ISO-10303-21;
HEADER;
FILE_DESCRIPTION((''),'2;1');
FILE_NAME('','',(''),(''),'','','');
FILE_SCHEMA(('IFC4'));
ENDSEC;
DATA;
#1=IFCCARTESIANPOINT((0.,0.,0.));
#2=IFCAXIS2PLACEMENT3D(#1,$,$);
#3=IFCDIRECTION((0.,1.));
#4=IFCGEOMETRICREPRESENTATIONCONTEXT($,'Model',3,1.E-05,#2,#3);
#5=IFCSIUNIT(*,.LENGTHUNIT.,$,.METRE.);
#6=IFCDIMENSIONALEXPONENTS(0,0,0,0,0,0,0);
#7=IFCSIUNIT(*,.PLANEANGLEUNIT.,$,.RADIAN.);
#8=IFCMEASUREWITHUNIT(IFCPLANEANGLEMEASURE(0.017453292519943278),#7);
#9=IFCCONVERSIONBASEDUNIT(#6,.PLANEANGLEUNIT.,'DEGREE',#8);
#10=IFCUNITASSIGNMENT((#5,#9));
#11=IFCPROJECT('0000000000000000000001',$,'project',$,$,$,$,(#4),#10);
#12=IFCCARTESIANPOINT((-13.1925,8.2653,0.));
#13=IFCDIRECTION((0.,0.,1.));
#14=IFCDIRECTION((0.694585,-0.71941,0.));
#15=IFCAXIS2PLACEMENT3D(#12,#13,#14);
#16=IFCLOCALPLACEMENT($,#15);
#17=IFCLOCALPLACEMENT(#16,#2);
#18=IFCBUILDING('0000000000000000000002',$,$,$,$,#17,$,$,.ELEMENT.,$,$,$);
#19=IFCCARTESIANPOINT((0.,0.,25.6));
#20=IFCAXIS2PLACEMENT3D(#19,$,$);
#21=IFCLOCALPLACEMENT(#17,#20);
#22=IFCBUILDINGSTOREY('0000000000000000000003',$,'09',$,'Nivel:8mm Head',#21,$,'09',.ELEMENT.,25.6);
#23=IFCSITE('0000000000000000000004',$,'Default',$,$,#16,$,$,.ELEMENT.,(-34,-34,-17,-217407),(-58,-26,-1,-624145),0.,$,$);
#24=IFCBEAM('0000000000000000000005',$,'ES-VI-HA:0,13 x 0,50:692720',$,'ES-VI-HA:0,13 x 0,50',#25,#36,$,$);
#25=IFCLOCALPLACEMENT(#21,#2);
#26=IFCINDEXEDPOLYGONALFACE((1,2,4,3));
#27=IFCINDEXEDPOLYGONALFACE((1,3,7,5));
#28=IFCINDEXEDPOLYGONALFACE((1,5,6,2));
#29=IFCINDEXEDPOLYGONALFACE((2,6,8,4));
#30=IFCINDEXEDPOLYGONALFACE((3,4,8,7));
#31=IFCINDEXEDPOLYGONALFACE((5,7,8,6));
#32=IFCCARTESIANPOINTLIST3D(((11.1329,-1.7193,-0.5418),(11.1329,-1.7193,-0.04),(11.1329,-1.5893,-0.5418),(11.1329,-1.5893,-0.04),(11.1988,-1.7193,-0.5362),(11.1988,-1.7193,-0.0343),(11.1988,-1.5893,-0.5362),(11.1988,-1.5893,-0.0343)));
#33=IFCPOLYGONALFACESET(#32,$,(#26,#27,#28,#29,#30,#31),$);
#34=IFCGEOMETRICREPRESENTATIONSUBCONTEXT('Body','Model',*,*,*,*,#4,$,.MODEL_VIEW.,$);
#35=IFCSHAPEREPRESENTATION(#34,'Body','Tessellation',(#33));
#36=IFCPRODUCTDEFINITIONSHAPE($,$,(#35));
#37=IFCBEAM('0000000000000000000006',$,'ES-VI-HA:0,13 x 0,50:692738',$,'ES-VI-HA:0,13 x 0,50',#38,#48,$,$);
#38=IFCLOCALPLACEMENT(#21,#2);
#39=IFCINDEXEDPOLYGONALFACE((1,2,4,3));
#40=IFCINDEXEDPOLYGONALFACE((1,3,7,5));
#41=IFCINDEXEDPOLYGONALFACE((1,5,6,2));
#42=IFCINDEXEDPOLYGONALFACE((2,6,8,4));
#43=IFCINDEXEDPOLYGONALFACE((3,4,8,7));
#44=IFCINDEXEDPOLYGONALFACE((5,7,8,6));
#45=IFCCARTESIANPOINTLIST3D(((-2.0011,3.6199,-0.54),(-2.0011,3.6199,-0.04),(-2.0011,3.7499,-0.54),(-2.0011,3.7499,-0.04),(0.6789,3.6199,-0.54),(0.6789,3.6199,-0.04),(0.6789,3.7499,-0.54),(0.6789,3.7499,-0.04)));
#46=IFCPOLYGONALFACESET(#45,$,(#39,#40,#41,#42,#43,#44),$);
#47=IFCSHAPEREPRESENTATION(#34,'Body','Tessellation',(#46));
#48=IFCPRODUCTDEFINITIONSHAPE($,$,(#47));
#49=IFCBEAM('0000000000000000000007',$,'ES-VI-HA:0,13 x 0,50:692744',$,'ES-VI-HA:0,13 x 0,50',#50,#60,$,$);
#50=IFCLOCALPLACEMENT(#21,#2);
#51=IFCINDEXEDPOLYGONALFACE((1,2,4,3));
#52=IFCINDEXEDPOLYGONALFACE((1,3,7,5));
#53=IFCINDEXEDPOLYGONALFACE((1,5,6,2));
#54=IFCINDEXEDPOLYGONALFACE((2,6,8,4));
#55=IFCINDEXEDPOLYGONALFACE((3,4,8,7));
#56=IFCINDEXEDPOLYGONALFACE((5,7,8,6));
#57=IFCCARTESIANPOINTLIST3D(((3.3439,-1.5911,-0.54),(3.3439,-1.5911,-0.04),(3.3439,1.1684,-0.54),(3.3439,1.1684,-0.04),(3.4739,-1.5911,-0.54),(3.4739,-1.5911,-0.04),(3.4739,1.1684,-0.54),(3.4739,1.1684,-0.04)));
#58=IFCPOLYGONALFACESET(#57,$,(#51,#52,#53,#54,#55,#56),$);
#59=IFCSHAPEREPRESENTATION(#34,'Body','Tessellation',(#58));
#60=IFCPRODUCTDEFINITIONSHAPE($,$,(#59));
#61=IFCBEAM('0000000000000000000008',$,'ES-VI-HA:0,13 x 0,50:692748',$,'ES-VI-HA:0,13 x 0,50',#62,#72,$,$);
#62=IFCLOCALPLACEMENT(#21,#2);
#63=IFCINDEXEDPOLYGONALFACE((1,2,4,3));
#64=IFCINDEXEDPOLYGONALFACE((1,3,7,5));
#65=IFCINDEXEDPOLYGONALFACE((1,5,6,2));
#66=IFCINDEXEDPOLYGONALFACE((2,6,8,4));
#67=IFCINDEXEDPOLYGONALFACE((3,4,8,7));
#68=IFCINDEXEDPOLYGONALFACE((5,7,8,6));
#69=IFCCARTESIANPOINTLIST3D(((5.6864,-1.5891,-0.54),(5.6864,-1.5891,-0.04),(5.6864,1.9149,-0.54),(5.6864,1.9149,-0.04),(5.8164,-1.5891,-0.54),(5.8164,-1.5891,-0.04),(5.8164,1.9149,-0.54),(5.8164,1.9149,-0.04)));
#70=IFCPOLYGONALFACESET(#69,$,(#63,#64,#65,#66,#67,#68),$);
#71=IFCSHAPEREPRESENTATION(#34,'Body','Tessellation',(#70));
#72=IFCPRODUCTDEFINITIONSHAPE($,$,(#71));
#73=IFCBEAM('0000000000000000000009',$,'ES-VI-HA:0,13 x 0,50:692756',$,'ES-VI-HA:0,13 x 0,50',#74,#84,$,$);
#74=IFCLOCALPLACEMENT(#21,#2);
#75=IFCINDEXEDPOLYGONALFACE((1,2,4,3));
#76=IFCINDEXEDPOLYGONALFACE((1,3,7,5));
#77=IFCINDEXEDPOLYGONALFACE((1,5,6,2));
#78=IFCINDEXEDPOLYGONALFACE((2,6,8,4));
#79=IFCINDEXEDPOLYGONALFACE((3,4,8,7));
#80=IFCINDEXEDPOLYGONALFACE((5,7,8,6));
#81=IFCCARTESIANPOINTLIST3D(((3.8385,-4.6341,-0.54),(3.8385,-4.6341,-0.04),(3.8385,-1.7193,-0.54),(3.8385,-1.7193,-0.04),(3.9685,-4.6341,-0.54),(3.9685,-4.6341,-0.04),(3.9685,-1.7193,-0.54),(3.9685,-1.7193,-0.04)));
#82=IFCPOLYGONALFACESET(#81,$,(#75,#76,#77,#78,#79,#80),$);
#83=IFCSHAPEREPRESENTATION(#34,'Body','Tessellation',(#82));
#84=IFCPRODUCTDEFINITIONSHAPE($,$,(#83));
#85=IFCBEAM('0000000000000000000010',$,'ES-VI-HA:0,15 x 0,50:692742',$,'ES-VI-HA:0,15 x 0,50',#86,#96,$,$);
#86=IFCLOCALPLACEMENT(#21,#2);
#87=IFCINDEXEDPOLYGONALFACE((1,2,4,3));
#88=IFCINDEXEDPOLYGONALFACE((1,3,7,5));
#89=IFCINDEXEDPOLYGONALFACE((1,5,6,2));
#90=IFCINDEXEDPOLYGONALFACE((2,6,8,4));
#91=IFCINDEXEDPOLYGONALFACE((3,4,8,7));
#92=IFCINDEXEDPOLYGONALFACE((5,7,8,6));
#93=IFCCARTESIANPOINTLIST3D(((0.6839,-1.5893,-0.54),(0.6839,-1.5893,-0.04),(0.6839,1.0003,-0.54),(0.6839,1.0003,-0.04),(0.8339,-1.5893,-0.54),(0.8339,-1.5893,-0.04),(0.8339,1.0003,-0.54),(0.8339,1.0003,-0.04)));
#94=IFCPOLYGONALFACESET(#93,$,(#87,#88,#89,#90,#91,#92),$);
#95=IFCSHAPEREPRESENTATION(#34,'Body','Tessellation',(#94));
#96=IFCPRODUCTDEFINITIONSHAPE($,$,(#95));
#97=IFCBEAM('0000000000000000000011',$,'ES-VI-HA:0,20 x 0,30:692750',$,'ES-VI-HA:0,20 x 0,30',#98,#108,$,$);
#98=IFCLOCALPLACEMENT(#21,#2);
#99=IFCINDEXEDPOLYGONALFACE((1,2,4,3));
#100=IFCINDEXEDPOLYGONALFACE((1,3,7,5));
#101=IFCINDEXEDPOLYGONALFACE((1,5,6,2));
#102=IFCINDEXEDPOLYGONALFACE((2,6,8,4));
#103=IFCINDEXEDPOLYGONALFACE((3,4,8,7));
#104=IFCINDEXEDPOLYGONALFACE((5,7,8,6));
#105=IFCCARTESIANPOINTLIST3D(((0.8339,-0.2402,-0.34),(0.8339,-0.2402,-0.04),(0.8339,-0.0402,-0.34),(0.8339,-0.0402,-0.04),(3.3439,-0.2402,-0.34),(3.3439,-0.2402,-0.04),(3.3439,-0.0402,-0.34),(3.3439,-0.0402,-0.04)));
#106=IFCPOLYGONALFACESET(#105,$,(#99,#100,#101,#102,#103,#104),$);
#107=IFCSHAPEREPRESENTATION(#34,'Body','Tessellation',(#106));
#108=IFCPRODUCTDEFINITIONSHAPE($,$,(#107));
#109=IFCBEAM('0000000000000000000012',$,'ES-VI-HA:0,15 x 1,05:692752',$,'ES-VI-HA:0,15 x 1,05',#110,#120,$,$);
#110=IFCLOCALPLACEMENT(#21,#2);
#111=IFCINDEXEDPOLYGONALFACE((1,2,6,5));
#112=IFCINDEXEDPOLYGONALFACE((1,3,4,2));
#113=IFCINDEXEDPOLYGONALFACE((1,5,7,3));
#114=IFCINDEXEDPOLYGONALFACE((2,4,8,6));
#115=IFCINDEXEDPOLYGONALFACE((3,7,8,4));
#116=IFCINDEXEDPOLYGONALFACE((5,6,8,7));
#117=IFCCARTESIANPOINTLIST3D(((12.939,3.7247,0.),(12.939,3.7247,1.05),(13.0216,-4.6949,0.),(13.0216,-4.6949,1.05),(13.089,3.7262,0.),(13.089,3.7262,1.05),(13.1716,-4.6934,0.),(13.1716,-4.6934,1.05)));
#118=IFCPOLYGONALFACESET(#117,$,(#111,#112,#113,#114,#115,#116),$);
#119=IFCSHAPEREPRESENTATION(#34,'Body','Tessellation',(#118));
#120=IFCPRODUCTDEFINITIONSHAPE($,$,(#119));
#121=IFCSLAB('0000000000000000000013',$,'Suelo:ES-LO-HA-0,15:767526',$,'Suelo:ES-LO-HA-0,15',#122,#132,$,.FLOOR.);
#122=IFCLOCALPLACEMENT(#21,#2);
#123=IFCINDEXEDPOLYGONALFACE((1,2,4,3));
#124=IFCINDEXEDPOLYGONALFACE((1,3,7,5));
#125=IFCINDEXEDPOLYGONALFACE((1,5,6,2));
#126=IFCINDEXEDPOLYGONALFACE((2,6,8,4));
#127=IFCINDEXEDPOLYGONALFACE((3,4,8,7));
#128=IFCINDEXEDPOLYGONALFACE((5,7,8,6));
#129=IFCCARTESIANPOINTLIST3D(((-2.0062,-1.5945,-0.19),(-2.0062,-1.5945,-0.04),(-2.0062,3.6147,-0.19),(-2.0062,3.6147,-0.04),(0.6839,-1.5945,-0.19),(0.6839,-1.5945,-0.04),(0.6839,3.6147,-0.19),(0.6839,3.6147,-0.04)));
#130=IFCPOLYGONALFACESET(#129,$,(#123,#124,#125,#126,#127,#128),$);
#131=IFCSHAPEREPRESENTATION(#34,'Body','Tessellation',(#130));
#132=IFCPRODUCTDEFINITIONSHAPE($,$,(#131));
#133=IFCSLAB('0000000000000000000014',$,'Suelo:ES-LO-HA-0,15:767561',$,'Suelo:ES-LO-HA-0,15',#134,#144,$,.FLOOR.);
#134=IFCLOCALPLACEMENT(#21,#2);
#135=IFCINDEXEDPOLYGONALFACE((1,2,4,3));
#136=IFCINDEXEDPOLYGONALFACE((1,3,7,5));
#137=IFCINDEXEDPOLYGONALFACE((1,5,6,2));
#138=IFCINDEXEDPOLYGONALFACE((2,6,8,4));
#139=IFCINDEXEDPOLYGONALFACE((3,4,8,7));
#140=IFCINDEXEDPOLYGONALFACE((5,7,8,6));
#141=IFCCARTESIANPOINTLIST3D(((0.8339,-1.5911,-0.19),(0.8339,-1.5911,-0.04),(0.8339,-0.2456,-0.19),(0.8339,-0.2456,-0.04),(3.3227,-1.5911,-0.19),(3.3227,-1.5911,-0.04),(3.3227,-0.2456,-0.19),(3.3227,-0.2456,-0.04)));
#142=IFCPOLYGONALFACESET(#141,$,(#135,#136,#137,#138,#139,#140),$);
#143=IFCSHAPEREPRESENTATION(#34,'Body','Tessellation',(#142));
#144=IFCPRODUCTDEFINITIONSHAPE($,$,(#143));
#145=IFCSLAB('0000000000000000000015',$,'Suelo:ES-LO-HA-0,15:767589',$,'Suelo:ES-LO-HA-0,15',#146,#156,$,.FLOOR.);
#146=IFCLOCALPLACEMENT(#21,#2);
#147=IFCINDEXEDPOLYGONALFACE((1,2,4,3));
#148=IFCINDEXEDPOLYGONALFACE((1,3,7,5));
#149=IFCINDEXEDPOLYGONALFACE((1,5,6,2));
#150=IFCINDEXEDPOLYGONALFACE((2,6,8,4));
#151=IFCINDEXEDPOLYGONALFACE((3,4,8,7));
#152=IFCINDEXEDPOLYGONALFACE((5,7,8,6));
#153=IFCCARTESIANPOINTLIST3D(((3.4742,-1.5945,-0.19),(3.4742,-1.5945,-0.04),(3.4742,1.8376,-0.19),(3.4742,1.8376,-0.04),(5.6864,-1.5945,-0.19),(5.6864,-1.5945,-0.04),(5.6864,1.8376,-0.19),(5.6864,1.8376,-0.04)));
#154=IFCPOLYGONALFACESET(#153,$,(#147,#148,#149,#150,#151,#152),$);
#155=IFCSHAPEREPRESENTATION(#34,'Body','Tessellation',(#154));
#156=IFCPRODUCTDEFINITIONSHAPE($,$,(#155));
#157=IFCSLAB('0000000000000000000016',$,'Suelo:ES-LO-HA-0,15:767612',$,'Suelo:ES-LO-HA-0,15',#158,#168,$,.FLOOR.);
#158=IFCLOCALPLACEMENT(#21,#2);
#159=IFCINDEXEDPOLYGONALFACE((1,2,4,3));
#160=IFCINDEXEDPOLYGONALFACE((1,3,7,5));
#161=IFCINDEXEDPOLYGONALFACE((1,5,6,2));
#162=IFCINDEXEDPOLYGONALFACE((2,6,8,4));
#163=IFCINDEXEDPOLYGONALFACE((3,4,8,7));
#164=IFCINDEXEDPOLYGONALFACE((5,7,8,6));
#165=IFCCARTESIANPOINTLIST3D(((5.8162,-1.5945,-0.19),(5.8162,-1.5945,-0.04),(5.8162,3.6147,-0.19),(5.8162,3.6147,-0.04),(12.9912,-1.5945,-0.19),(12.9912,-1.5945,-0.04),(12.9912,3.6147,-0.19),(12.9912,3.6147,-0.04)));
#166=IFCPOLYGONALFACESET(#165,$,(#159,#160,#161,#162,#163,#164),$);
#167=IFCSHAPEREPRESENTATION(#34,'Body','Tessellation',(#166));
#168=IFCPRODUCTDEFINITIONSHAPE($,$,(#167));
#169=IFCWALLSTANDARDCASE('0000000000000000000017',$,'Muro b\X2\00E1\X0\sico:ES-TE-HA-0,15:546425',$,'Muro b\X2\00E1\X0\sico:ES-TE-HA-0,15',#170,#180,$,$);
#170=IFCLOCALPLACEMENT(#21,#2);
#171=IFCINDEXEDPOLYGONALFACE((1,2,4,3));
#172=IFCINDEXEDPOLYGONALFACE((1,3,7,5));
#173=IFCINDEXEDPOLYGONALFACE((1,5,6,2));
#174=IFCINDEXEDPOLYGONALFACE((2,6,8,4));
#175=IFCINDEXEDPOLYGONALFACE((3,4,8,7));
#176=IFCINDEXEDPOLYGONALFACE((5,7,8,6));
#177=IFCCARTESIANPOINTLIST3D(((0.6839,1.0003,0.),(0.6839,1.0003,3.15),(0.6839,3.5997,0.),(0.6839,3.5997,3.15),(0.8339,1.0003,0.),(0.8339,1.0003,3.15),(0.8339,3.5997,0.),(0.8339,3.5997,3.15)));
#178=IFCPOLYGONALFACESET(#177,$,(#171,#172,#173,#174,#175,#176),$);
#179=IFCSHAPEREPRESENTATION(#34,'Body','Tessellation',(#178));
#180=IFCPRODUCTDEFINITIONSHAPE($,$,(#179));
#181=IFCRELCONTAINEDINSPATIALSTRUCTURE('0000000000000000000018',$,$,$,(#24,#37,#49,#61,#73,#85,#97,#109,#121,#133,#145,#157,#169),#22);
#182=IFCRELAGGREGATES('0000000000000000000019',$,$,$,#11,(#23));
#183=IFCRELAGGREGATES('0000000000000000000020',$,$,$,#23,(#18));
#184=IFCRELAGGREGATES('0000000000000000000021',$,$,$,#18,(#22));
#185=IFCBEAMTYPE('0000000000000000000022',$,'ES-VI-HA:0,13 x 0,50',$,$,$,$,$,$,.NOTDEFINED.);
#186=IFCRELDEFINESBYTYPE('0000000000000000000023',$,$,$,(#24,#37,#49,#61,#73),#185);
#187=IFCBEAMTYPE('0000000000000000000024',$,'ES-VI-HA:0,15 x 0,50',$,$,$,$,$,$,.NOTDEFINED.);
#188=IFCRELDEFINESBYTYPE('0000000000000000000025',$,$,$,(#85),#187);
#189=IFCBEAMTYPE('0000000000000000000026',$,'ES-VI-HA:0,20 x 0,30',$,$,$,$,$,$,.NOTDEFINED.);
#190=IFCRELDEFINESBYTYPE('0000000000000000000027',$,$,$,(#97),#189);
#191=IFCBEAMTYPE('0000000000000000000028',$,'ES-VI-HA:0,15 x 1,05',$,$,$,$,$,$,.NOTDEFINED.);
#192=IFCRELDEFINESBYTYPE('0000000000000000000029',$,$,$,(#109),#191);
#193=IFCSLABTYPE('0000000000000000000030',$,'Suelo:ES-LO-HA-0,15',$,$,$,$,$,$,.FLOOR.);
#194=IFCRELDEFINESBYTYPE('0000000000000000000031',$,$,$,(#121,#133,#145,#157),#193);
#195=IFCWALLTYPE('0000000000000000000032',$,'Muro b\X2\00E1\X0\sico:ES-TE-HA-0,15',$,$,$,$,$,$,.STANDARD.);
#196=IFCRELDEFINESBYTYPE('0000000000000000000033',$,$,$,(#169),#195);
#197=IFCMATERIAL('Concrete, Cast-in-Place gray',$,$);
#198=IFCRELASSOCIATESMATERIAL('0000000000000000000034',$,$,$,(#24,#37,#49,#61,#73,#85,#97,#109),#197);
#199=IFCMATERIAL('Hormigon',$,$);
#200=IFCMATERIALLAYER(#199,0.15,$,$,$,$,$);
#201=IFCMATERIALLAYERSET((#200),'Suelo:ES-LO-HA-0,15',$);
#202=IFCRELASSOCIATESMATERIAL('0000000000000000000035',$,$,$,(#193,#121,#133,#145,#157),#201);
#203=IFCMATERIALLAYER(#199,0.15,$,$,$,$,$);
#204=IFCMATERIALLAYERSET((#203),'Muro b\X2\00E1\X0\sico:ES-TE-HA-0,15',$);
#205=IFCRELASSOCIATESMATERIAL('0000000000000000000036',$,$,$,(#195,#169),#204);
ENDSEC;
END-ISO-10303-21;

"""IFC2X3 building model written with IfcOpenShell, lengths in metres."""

from ifc_helpers import new_model, entity, si_unit, converted_unit, direction, frame, frame_2d, origin, origin_2d_with_axis, place, context, subcontext, project, spatial, rectangle, extrude, clip, halfspace, material, layer, layer_set, layer_usage, type_object, element, save


model = new_model("IFC2X3")

# Units and contexts
model_context = context("Model", 3, precision=1e-05, world=origin(), true_north=direction((0.0, 1.0)))
body_context = subcontext(model_context, "Body", "Model", "MODEL_VIEW")
ifc_project = project(units=[si_unit("LENGTHUNIT", "METRE"), converted_unit("PLANEANGLEUNIT", "DEGREE", entity("IfcPlaneAngleMeasure", 0.017453292519943278), si_unit("PLANEANGLEUNIT", "RADIAN"), dimensions=[0, 0, 0, 0, 0, 0, 0])], contexts=[model_context])

# Site, building, storey
site_placement = place(None, frame((-13.1925, 8.2653, 0.0), z_axis=(0.0, 0.0, 1.0), x_axis=(0.694585, -0.71941, 0.0)))
site = spatial("IfcSite", under=ifc_project, at=site_placement, Name="Default", CompositionType="ELEMENT", RefLatitude=(-34, -34, -17, -217407), RefLongitude=(-58, -26, -1, -624145), RefElevation=0.0)
building_placement = place(site_placement, origin())
building = spatial("IfcBuilding", under=site, at=building_placement, CompositionType="ELEMENT")
storey_placement = place(building_placement, frame((0.0, 0.0, 25.6)))
storey = spatial("IfcBuildingStorey", under=building, at=storey_placement, Name="09", ObjectType="Nivel:8mm Head", LongName="09", CompositionType="ELEMENT", Elevation=25.6)

# Beams
ifc_material_1 = material(Name="Concrete, Cast-in-Place gray")
beam_type_1 = type_object("IfcBeamType", Name="ES-VI-HA:0,13 x 0,50", PredefinedType="NOTDEFINED")
beam_1_placement = place(storey_placement, frame((11.1329, -1.6543, -0.04), z_axis=(-0.08555, 0.0, 0.996334), x_axis=(0.996334, 0.0, 0.08555)))
element("IfcBeam", 1, at=beam_1_placement, inside=storey, type_object=beam_type_1, material=ifc_material_1, Name="ES-VI-HA:0,13 x 0,50:692720", ObjectType="ES-VI-HA:0,13 x 0,50", context=body_context, shape_type="SweptSolid", body=[
    clip(clip(extrude(rectangle(XDim=0.5, YDim=0.13, at=frame_2d((0.0, 0.0), x_axis=(1.0, 0.0))), frame((-0.0429, 0.0, -0.25), z_axis=(1.0, 0.0, 0.0), x_axis=(0.0, 0.0, -1.0)), (0.0, 0.0, 1.0), 0.109), halfspace(frame((0.0, 0.0, 0.0), z_axis=(-0.996334, 0.0, 0.08555), x_axis=(0.0, -1.0, 0.0)), False)), halfspace(frame((0.069, 0.065, 0.0342), z_axis=(0.996334, 0.0, -0.08555), x_axis=(-0.08555, 0.0, -0.996334)), False)),
])
beam_2_placement = place(storey_placement, frame((-2.0011, 3.6849, -0.04)))
element("IfcBeam", 2, at=beam_2_placement, inside=storey, type_object=beam_type_1, material=ifc_material_1, Name="ES-VI-HA:0,13 x 0,50:692738", ObjectType="ES-VI-HA:0,13 x 0,50", context=body_context, shape_type="SweptSolid", body=[
    extrude(rectangle(XDim=0.5, YDim=0.13, at=frame_2d((0.0, 0.0), x_axis=(1.0, 0.0))), frame((0.0, 0.0, -0.25), z_axis=(1.0, 0.0, 0.0), x_axis=(0.0, 0.0, -1.0)), (0.0, 0.0, 1.0), 2.68),
])
beam_3_placement = place(storey_placement, frame((3.4089, -1.5916, -0.04), z_axis=(0.0, 0.0, 1.0), x_axis=(0.0, 1.0, 0.0)))
element("IfcBeam", 3, at=beam_3_placement, inside=storey, type_object=beam_type_1, material=ifc_material_1, Name="ES-VI-HA:0,13 x 0,50:692744", ObjectType="ES-VI-HA:0,13 x 0,50", context=body_context, shape_type="SweptSolid", body=[
    extrude(rectangle(XDim=0.5, YDim=0.13, at=frame_2d((0.0, 0.0), x_axis=(1.0, 0.0))), frame((0.0005, 0.0, -0.25), z_axis=(1.0, 0.0, 0.0), x_axis=(0.0, 0.0, -1.0)), (0.0, 0.0, 1.0), 2.7595),
])
beam_4_placement = place(storey_placement, frame((5.7514, -1.5891, -0.04), z_axis=(0.0, 0.0, 1.0), x_axis=(0.0, 1.0, 0.0)))
element("IfcBeam", 4, at=beam_4_placement, inside=storey, type_object=beam_type_1, material=ifc_material_1, Name="ES-VI-HA:0,13 x 0,50:692748", ObjectType="ES-VI-HA:0,13 x 0,50", context=body_context, shape_type="SweptSolid", body=[
    extrude(rectangle(XDim=0.5, YDim=0.13, at=frame_2d((0.0, 0.0), x_axis=(1.0, 0.0))), frame((0.0, 0.0, -0.25), z_axis=(1.0, 0.0, 0.0), x_axis=(0.0, 0.0, -1.0)), (0.0, 0.0, 1.0), 3.5039),
])
beam_5_placement = place(storey_placement, frame((3.9035, -4.7011, -0.04), z_axis=(0.0, 0.0, 1.0), x_axis=(0.0, 1.0, 0.0)))
element("IfcBeam", 5, at=beam_5_placement, inside=storey, type_object=beam_type_1, material=ifc_material_1, Name="ES-VI-HA:0,13 x 0,50:692756", ObjectType="ES-VI-HA:0,13 x 0,50", context=body_context, shape_type="SweptSolid", body=[
    extrude(rectangle(XDim=0.5, YDim=0.13, at=origin_2d_with_axis()), frame((0.067, 0.0, -0.25), z_axis=(1.0, 0.0, 0.0), x_axis=(0.0, 0.0, -1.0)), (0.0, 0.0, 1.0), 2.9148),
])
beam_type_2 = type_object("IfcBeamType", Name="ES-VI-HA:0,15 x 0,50", PredefinedType="NOTDEFINED")
beam_6_placement = place(storey_placement, frame((0.7589, -1.6543, -0.04), z_axis=(0.0, 0.0, 1.0), x_axis=(0.0, 1.0, 0.0)))
element("IfcBeam", 6, at=beam_6_placement, inside=storey, type_object=beam_type_2, material=ifc_material_1, Name="ES-VI-HA:0,15 x 0,50:692742", ObjectType="ES-VI-HA:0,15 x 0,50", context=body_context, shape_type="SweptSolid", body=[
    extrude(rectangle(XDim=0.5, YDim=0.15, at=frame_2d((0.0, 0.0), x_axis=(1.0, 0.0))), frame((0.065, 0.0, -0.25), z_axis=(1.0, 0.0, 0.0), x_axis=(0.0, 0.0, -1.0)), (0.0, 0.0, 1.0), 2.5896),
])
beam_type_3 = type_object("IfcBeamType", Name="ES-VI-HA:0,20 x 0,30", PredefinedType="NOTDEFINED")
beam_7_placement = place(storey_placement, frame((0.7589, -0.1402, -0.04)))
element("IfcBeam", 7, at=beam_7_placement, inside=storey, type_object=beam_type_3, material=ifc_material_1, Name="ES-VI-HA:0,20 x 0,30:692750", ObjectType="ES-VI-HA:0,20 x 0,30", context=body_context, shape_type="SweptSolid", body=[
    extrude(rectangle(XDim=0.3, YDim=0.2, at=frame_2d((0.0, 0.0), x_axis=(1.0, 0.0))), frame((0.075, 0.0, -0.15), z_axis=(1.0, 0.0, 0.0), x_axis=(0.0, 0.0, -1.0)), (0.0, 0.0, 1.0), 2.51),
])
beam_type_4 = type_object("IfcBeamType", Name="ES-VI-HA:0,15 x 1,05", PredefinedType="NOTDEFINED")
beam_8_placement = place(storey_placement, frame((13.014, 3.7254, 1.05), z_axis=(0.0, 0.0, 1.0), x_axis=(0.009814, -0.999952, 0.0)))
element("IfcBeam", 8, at=beam_8_placement, inside=storey, type_object=beam_type_4, material=ifc_material_1, Name="ES-VI-HA:0,15 x 1,05:692752", ObjectType="ES-VI-HA:0,15 x 1,05", context=body_context, shape_type="SweptSolid", body=[
    extrude(rectangle(XDim=1.05, YDim=0.15, at=frame_2d((0.0, 0.0), x_axis=(1.0, 0.0))), frame((0.0, 0.0, -0.525), z_axis=(1.0, 0.0, 0.0), x_axis=(0.0, 0.0, -1.0)), (0.0, 0.0, 1.0), 8.42),
])

# Slabs
ifc_material_2 = material(Name="Hormigon")
ifc_layer_1 = layer(ifc_material_2, 0.15)
ifc_layer_set_1 = layer_set([ifc_layer_1], Name="Suelo:ES-LO-HA-0,15")
slab_type_1 = type_object("IfcSlabType", Name="Suelo:ES-LO-HA-0,15", PredefinedType="FLOOR", material=ifc_layer_set_1)
ifc_layer_usage_1 = layer_usage(ifc_layer_set_1, "AXIS3", "POSITIVE", 0.0)
slab_1_placement = place(storey_placement, origin())
element("IfcSlab", 9, at=slab_1_placement, inside=storey, type_object=slab_type_1, material=ifc_layer_usage_1, Name="Suelo:ES-LO-HA-0,15:767526", ObjectType="Suelo:ES-LO-HA-0,15", PredefinedType="FLOOR", context=body_context, shape_type="SweptSolid", body=[
    extrude(rectangle(XDim=5.2092, YDim=2.6902, at=origin_2d_with_axis()), frame((-0.6611, 1.0101, -0.04), z_axis=(0.0, 0.0, -1.0), x_axis=(0.0, 1.0, 0.0)), (0.0, 0.0, 1.0), 0.15),
])
ifc_layer_usage_2 = layer_usage(ifc_layer_set_1, "AXIS3", "POSITIVE", 0.0)
slab_2_placement = place(storey_placement, origin())
element("IfcSlab", 10, at=slab_2_placement, inside=storey, type_object=slab_type_1, material=ifc_layer_usage_2, Name="Suelo:ES-LO-HA-0,15:767561", ObjectType="Suelo:ES-LO-HA-0,15", PredefinedType="FLOOR", context=body_context, shape_type="SweptSolid", body=[
    extrude(rectangle(XDim=1.3455, YDim=2.4888, at=frame_2d((0.0, 0.0), x_axis=(1.0, 0.0))), frame((2.0783, -0.9183, -0.04), z_axis=(0.0, 0.0, -1.0), x_axis=(0.0, 1.0, 0.0)), (0.0, 0.0, 1.0), 0.15),
])
ifc_layer_usage_3 = layer_usage(ifc_layer_set_1, "AXIS3", "POSITIVE", 0.0)
slab_3_placement = place(storey_placement, origin())
element("IfcSlab", 11, at=slab_3_placement, inside=storey, type_object=slab_type_1, material=ifc_layer_usage_3, Name="Suelo:ES-LO-HA-0,15:767589", ObjectType="Suelo:ES-LO-HA-0,15", PredefinedType="FLOOR", context=body_context, shape_type="SweptSolid", body=[
    extrude(rectangle(XDim=3.4321, YDim=2.2122, at=origin_2d_with_axis()), frame((4.5803, 0.1216, -0.04), z_axis=(0.0, 0.0, -1.0), x_axis=(0.0, 1.0, 0.0)), (0.0, 0.0, 1.0), 0.15),
])
ifc_layer_usage_4 = layer_usage(ifc_layer_set_1, "AXIS3", "POSITIVE", 0.0)
slab_4_placement = place(storey_placement, origin())
element("IfcSlab", 12, at=slab_4_placement, inside=storey, type_object=slab_type_1, material=ifc_layer_usage_4, Name="Suelo:ES-LO-HA-0,15:767612", ObjectType="Suelo:ES-LO-HA-0,15", PredefinedType="FLOOR", context=body_context, shape_type="SweptSolid", body=[
    extrude(rectangle(XDim=5.2092, YDim=7.175, at=origin_2d_with_axis()), frame((9.4037, 1.0101, -0.04), z_axis=(0.0, 0.0, -1.0), x_axis=(0.0, 1.0, 0.0)), (0.0, 0.0, 1.0), 0.15),
])

# Wall
ifc_layer_2 = layer(ifc_material_2, 0.15)
ifc_layer_set_2 = layer_set([ifc_layer_2], Name="Muro básico:ES-TE-HA-0,15")
ifc_layer_usage_5 = layer_usage(ifc_layer_set_2, "AXIS2", "NEGATIVE", 0.075)
wall_type = type_object("IfcWallType", Name="Muro básico:ES-TE-HA-0,15", PredefinedType="STANDARD", material=ifc_layer_set_2)
wall_1_placement = place(storey_placement, frame((0.7589, 1.0003, 0.0), z_axis=(0.0, 0.0, 1.0), x_axis=(0.0, 1.0, 0.0)))
element("IfcWallStandardCase", 13, at=wall_1_placement, inside=storey, type_object=wall_type, material=ifc_layer_usage_5, Name="Muro básico:ES-TE-HA-0,15:546425", ObjectType="Muro básico:ES-TE-HA-0,15", context=body_context, shape_type="SweptSolid", body=[
    extrude(rectangle(XDim=2.5994, YDim=0.15, at=frame_2d((1.2997, 0.0), x_axis=(-1.0, 0.0))), origin(), (0.0, 0.0, 1.0), 3.15),
])

save(model, "model.ifc")
